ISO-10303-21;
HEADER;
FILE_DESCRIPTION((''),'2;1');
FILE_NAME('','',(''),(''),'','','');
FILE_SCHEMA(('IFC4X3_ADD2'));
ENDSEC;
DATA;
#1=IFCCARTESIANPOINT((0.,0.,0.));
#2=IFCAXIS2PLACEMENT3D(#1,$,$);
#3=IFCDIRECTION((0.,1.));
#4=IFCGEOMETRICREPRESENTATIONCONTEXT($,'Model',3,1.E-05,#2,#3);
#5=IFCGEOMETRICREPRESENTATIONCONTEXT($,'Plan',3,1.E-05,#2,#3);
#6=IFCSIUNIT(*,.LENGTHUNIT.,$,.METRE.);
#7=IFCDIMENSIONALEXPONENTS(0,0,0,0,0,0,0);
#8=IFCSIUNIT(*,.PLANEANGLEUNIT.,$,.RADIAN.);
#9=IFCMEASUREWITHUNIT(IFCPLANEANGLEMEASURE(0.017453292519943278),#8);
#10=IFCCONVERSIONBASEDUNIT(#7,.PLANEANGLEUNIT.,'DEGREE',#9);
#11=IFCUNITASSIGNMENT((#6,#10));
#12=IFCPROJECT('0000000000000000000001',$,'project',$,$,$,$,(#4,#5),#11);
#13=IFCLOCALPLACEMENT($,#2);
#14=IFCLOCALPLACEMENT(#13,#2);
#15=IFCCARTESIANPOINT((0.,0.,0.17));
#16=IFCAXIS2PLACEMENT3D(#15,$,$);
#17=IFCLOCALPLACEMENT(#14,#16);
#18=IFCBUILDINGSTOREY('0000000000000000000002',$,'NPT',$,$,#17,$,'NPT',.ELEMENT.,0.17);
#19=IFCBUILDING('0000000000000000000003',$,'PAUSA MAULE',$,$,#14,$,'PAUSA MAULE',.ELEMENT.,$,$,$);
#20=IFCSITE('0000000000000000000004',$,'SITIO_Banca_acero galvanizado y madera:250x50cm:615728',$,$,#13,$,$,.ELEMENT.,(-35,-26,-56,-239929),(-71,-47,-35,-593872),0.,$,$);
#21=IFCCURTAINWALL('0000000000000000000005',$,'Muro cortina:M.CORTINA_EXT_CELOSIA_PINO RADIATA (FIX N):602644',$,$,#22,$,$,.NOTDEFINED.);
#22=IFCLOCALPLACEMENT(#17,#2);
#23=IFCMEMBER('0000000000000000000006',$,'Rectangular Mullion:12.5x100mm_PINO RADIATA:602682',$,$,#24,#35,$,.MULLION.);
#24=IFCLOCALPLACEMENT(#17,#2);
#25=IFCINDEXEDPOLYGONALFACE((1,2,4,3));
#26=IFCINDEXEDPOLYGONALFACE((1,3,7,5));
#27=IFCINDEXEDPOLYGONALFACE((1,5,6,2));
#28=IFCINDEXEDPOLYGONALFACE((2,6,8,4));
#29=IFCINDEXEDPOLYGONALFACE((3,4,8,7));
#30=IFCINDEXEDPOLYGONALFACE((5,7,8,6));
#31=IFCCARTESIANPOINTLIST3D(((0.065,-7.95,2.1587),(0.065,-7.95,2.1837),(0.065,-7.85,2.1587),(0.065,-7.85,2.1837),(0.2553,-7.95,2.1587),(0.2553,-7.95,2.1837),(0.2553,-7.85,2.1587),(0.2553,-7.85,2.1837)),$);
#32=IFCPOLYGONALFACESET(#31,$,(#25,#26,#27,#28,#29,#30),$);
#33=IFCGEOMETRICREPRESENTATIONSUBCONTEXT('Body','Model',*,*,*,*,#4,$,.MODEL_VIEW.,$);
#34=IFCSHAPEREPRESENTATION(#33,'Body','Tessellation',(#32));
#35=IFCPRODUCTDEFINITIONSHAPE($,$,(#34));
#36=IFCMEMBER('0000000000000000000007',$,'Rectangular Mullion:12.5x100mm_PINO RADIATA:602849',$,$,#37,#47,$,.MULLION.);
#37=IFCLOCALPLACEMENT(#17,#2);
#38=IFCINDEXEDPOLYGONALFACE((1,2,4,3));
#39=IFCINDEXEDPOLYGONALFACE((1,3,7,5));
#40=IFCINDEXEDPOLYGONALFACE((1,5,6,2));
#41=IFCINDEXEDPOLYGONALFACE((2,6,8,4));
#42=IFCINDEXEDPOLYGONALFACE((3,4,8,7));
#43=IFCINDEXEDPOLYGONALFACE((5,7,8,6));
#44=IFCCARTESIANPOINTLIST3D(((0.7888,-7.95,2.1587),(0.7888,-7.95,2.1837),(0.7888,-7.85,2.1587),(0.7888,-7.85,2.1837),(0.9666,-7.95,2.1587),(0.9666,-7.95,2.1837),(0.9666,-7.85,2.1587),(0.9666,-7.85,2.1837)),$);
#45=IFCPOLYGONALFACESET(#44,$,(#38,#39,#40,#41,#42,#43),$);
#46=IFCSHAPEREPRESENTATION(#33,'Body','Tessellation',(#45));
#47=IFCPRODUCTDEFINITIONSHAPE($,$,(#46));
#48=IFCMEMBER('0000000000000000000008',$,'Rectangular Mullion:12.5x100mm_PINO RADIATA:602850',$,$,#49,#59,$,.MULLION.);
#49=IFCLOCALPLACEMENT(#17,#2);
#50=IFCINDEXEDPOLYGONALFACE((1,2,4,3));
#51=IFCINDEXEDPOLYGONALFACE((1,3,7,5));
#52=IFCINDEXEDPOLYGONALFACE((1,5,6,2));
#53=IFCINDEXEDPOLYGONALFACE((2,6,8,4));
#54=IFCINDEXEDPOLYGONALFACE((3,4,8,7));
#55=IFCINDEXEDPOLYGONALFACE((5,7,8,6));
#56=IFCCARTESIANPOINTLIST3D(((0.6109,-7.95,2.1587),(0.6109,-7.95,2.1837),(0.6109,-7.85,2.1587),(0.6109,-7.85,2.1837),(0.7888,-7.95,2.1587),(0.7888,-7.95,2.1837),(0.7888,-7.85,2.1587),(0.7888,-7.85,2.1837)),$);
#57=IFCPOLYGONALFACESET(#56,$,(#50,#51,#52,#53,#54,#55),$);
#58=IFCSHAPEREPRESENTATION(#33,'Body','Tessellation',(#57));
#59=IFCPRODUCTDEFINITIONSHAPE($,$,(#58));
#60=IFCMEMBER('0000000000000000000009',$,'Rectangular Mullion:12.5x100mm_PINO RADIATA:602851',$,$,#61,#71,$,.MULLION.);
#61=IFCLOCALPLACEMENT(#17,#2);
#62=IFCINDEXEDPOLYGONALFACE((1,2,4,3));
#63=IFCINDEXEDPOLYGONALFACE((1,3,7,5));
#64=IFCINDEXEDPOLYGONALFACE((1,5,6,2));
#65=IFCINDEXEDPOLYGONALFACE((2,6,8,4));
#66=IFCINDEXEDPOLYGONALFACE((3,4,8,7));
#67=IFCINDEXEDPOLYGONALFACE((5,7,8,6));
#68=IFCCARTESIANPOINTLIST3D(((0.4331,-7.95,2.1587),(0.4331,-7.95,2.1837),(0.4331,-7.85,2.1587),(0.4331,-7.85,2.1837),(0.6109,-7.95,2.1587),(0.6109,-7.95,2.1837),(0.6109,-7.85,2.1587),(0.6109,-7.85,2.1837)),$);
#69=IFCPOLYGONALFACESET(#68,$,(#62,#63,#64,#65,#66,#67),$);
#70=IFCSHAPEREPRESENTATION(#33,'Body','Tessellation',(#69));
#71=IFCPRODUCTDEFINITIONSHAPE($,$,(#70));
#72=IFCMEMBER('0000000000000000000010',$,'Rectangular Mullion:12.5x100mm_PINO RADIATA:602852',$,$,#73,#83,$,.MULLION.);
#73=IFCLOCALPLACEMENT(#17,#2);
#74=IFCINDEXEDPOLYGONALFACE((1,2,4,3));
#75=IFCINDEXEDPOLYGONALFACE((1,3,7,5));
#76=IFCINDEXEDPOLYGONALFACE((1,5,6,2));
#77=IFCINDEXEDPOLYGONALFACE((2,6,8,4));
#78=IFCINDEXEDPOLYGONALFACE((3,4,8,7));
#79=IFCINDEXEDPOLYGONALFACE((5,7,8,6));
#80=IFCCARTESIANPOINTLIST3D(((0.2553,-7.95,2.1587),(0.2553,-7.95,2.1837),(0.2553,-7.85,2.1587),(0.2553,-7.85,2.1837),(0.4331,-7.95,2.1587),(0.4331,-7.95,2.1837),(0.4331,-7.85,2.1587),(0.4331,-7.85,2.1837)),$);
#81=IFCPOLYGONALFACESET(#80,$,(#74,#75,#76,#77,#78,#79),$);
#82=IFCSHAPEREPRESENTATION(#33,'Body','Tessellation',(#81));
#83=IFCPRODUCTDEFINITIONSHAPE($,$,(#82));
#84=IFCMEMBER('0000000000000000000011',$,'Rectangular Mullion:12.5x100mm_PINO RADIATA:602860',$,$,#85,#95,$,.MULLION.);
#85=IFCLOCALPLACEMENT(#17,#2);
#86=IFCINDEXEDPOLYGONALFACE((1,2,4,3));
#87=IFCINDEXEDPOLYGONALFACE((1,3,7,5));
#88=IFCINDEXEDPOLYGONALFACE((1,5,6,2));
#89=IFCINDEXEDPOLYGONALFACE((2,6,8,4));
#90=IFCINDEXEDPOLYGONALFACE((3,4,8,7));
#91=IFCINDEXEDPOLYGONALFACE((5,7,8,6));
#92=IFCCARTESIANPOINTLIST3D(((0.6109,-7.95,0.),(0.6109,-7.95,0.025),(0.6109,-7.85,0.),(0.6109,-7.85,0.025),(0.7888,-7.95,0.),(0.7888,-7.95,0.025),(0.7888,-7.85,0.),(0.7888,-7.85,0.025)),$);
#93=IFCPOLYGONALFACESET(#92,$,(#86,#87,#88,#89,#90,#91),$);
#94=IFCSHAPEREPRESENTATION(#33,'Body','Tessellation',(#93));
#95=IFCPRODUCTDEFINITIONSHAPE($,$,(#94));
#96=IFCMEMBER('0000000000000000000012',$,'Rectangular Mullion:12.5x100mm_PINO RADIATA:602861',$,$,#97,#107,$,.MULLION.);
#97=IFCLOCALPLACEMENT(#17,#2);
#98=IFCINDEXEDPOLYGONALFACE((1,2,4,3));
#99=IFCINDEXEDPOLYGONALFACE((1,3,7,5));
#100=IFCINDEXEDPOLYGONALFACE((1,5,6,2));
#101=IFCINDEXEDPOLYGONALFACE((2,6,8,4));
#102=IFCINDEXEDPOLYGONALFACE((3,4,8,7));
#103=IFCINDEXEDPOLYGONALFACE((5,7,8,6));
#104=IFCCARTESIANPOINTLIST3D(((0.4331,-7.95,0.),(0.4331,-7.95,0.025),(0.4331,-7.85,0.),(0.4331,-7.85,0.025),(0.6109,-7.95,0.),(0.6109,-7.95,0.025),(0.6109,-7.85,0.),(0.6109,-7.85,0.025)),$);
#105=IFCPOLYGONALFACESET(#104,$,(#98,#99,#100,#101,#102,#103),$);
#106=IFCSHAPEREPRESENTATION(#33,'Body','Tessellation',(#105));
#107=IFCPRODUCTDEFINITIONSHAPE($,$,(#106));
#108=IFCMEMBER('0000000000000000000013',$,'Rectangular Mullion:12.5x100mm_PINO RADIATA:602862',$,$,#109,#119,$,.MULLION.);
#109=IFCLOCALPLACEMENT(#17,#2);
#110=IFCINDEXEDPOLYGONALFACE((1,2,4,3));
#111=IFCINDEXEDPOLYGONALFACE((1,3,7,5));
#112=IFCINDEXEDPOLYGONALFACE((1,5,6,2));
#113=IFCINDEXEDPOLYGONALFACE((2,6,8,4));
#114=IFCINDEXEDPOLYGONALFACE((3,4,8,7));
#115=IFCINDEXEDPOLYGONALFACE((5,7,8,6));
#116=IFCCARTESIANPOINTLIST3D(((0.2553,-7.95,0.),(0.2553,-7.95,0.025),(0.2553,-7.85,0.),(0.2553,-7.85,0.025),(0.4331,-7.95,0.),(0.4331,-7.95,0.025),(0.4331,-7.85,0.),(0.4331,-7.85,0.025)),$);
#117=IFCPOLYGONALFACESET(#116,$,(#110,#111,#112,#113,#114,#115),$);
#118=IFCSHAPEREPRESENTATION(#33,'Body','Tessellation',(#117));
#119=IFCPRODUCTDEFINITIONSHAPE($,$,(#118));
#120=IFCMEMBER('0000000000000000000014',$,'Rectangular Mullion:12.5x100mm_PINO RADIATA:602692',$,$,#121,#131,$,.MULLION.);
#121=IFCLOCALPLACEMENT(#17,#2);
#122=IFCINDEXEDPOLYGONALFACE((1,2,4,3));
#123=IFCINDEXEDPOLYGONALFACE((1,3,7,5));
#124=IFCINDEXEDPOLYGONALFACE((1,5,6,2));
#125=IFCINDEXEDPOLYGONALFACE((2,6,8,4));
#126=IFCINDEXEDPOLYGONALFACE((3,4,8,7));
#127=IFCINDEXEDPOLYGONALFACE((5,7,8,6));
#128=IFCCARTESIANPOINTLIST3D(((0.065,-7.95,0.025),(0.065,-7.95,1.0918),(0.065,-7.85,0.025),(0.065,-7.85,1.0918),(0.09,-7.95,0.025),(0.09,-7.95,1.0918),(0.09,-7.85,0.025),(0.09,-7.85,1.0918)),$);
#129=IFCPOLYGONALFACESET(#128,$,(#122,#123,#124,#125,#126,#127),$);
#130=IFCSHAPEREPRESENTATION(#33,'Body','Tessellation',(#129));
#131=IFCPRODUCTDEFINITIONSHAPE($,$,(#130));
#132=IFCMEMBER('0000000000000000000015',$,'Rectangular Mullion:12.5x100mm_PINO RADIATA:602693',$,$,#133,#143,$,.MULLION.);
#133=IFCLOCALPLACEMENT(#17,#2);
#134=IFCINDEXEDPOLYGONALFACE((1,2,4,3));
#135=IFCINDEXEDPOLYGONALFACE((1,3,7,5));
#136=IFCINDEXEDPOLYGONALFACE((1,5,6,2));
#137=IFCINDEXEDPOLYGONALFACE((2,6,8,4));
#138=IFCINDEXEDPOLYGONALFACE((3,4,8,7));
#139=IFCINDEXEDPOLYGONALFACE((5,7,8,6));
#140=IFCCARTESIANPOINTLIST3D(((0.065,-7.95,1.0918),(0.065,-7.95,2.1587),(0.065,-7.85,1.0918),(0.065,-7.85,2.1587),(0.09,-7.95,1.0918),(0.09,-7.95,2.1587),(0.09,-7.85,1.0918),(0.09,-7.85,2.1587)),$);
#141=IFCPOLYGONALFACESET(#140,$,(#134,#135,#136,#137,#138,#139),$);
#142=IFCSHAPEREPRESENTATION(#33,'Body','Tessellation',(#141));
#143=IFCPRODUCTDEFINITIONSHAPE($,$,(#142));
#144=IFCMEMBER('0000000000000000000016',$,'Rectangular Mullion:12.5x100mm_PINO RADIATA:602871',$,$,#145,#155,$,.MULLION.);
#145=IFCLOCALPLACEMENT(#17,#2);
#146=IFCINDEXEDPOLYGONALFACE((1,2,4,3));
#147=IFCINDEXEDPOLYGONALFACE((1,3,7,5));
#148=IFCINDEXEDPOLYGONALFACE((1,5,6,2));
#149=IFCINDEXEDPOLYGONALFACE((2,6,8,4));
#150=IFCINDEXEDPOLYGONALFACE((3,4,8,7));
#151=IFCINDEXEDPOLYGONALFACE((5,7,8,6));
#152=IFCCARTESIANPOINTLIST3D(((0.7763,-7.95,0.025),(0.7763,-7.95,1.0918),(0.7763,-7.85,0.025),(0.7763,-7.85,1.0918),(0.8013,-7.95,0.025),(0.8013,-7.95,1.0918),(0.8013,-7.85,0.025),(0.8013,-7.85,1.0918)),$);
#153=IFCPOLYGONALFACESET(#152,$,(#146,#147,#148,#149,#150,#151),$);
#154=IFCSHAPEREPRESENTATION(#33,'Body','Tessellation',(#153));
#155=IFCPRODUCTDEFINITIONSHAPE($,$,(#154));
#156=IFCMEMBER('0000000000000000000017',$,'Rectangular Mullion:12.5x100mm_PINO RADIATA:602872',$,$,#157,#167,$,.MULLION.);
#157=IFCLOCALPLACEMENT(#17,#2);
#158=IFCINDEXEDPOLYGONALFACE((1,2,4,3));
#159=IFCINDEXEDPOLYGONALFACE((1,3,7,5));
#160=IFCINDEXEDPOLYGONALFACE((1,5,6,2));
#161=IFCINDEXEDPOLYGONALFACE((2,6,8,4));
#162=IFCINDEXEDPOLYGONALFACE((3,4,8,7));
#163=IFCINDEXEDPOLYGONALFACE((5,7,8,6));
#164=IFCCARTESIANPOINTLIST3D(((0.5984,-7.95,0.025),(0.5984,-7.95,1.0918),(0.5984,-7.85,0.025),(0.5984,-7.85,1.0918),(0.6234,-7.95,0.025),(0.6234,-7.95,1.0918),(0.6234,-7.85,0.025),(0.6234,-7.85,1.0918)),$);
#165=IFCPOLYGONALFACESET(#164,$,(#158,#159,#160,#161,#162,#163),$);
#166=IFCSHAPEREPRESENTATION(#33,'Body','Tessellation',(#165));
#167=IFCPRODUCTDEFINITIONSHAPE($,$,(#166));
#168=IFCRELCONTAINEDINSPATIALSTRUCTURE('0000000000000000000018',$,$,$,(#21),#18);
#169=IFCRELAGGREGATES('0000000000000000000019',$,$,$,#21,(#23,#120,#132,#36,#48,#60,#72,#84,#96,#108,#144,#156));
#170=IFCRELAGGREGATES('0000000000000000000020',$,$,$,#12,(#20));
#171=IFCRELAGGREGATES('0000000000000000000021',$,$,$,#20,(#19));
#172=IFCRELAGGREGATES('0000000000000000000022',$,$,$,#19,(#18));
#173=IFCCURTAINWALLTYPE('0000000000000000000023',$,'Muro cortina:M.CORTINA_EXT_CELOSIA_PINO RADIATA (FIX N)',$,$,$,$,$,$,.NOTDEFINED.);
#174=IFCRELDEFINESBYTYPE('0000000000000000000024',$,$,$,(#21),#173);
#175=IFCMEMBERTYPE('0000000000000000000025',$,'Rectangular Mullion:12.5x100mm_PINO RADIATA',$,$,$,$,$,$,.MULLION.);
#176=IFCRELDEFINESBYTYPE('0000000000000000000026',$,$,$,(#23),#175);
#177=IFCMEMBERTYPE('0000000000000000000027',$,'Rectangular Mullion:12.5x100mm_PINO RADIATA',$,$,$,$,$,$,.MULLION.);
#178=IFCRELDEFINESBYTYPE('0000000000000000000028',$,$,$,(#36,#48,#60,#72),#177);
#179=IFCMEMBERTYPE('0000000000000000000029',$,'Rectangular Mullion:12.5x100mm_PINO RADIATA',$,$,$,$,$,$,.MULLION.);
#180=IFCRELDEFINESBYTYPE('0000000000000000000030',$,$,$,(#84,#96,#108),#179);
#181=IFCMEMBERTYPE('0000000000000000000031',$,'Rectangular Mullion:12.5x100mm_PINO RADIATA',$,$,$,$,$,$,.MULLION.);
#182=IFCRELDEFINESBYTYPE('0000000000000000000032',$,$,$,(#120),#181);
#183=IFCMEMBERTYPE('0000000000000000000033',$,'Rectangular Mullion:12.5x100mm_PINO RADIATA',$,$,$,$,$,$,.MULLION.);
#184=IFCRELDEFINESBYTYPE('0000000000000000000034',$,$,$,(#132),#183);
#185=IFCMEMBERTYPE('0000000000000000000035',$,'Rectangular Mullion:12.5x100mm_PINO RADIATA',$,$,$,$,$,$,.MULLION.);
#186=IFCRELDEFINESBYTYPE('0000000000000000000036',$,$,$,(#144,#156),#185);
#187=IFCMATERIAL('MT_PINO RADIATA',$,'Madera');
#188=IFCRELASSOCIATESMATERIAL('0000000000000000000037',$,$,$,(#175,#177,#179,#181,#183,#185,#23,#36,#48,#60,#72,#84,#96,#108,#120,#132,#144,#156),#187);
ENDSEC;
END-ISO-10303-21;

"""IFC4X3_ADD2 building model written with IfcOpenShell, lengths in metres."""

from ifc_helpers import new_model, entity, si_unit, converted_unit, direction, frame, frame_2d, origin, origin_2d_with_axis, place, context, subcontext, project, spatial, rectangle, extrude, source, transform, mapped, material, material_profile, profile_set, profile_usage, type_object, type_shapes, element, aggregate, save


model = new_model("IFC4X3_ADD2")

# Units and contexts
model_context = context("Model", 3, precision=1e-05, world=origin(), true_north=direction((0.0, 1.0)))
plan_context = context("Plan", 3, precision=1e-05, world=origin(), true_north=direction((0.0, 1.0)))
body_context = subcontext(model_context, "Body", "Model", "MODEL_VIEW")
ifc_project = project(units=[si_unit("LENGTHUNIT", "METRE"), converted_unit("PLANEANGLEUNIT", "DEGREE", entity("IfcPlaneAngleMeasure", 0.017453292519943278), si_unit("PLANEANGLEUNIT", "RADIAN"), dimensions=[0, 0, 0, 0, 0, 0, 0])], contexts=[model_context, plan_context])

# Site, building, storey
site_placement = place(None, origin())
site = spatial("IfcSite", under=ifc_project, at=site_placement, Name="SITIO_Banca_acero galvanizado y madera:250x50cm:615728", CompositionType="ELEMENT", RefLatitude=(-35, -26, -56, -239929), RefLongitude=(-71, -47, -35, -593872), RefElevation=0.0)
building_placement = place(site_placement, origin())
building = spatial("IfcBuilding", under=site, at=building_placement, Name="PAUSA MAULE", LongName="PAUSA MAULE", CompositionType="ELEMENT")
storey_placement = place(building_placement, frame((0.0, 0.0, 0.17)))
storey = spatial("IfcBuildingStorey", under=building, at=storey_placement, Name="NPT", LongName="NPT", CompositionType="ELEMENT", Elevation=0.17)

# Curtain wall, members
curtain_wall_type = type_object("IfcCurtainWallType", Name="Muro cortina:M.CORTINA_EXT_CELOSIA_PINO RADIATA (FIX N)", PredefinedType="NOTDEFINED")
curtain_wall_placement = place(storey_placement, frame((0.0, 0.0, -0.17)))
curtain_wall = element("IfcCurtainWall", 1, at=curtain_wall_placement, inside=storey, type_object=curtain_wall_type, Name="Muro cortina:M.CORTINA_EXT_CELOSIA_PINO RADIATA (FIX N):602644", PredefinedType="NOTDEFINED")
ifc_material_1 = material(Name="MT_PINO RADIATA", Category="Madera")
ifc_material_profile = material_profile(ifc_material_1, rectangle(XDim=0.025, YDim=0.1, at=frame_2d((0.0, 0.0), x_axis=(1.0, 0.0))), Name="12.5x100mm_PINO RADIATA")
ifc_profile_set = profile_set([ifc_material_profile], Name="12.5x100mm_PINO RADIATA")
ifc_profile_usage = profile_usage(ifc_profile_set)
member_type_1 = type_object("IfcMemberType", Name="Rectangular Mullion:12.5x100mm_PINO RADIATA", PredefinedType="MULLION", material=ifc_profile_set)
shared_shape_1 = source(origin(), body_context, "Body", "SweptSolid", [
    extrude(rectangle(XDim=0.025, YDim=0.1, at=frame_2d((0.0, 0.0), x_axis=(1.0, 0.0))), frame((-0.0125, 0.0, -0.1903), z_axis=(0.0, 0.0, 1.0), x_axis=(-1.0, 0.0, 0.0)), (0.0, 0.0, 1.0), 0.1903),
])
type_shapes(member_type_1, [shared_shape_1])
member_1_placement = place(curtain_wall_placement, frame((0.065, -7.9, 2.3537), z_axis=(-1.0, 0.0, 0.0), x_axis=(0.0, 0.0, 1.0)))
member_1 = element("IfcMember", 2, at=member_1_placement, type_object=member_type_1, material=ifc_profile_usage, Name="Rectangular Mullion:12.5x100mm_PINO RADIATA:602682", PredefinedType="MULLION", context=body_context, shape_type="MappedRepresentation", body=[
    mapped(shared_shape_1, transform((0.0, 0.0, 0.0), scale=1.0)),
])
member_type_2 = type_object("IfcMemberType", Name="Rectangular Mullion:12.5x100mm_PINO RADIATA", PredefinedType="MULLION", material=ifc_profile_set)
shared_shape_2 = source(origin(), body_context, "Body", "SweptSolid", [
    extrude(rectangle(XDim=0.025, YDim=0.1, at=frame_2d((0.0, 0.0), x_axis=(1.0, 0.0))), frame((-0.0125, 0.0, -0.1778), z_axis=(0.0, 0.0, 1.0), x_axis=(-1.0, 0.0, 0.0)), (0.0, 0.0, 1.0), 0.1778),
])
type_shapes(member_type_2, [shared_shape_2])
member_2_placement = place(curtain_wall_placement, frame((0.7888, -7.9, 2.3537), z_axis=(-1.0, 0.0, 0.0), x_axis=(0.0, 0.0, 1.0)))
member_2 = element("IfcMember", 3, at=member_2_placement, type_object=member_type_2, material=ifc_profile_usage, Name="Rectangular Mullion:12.5x100mm_PINO RADIATA:602849", PredefinedType="MULLION", context=body_context, shape_type="MappedRepresentation", body=[
    mapped(shared_shape_2, transform((0.0, 0.0, 0.0), scale=1.0)),
])
member_3_placement = place(curtain_wall_placement, frame((0.6109, -7.9, 2.3537), z_axis=(-1.0, 0.0, 0.0), x_axis=(0.0, 0.0, 1.0)))
member_3 = element("IfcMember", 4, at=member_3_placement, type_object=member_type_2, material=ifc_profile_usage, Name="Rectangular Mullion:12.5x100mm_PINO RADIATA:602850", PredefinedType="MULLION", context=body_context, shape_type="MappedRepresentation", body=[
    mapped(shared_shape_2, transform((0.0, 0.0, 0.0), scale=1.0)),
])
member_4_placement = place(curtain_wall_placement, frame((0.4331, -7.9, 2.3537), z_axis=(-1.0, 0.0, 0.0), x_axis=(0.0, 0.0, 1.0)))
member_4 = element("IfcMember", 5, at=member_4_placement, type_object=member_type_2, material=ifc_profile_usage, Name="Rectangular Mullion:12.5x100mm_PINO RADIATA:602851", PredefinedType="MULLION", context=body_context, shape_type="MappedRepresentation", body=[
    mapped(shared_shape_2, transform((0.0, 0.0, 0.0), scale=1.0)),
])
member_5_placement = place(curtain_wall_placement, frame((0.2553, -7.9, 2.3537), z_axis=(-1.0, 0.0, 0.0), x_axis=(0.0, 0.0, 1.0)))
member_5 = element("IfcMember", 6, at=member_5_placement, type_object=member_type_2, material=ifc_profile_usage, Name="Rectangular Mullion:12.5x100mm_PINO RADIATA:602852", PredefinedType="MULLION", context=body_context, shape_type="MappedRepresentation", body=[
    mapped(shared_shape_2, transform((0.0, 0.0, 0.0), scale=1.0)),
])
member_type_3 = type_object("IfcMemberType", Name="Rectangular Mullion:12.5x100mm_PINO RADIATA", PredefinedType="MULLION", material=ifc_profile_set)
shared_shape_3 = source(origin(), body_context, "Body", "SweptSolid", [
    extrude(rectangle(XDim=0.025, YDim=0.1, at=frame_2d((0.0, 0.0), x_axis=(1.0, 0.0))), frame((-0.0125, 0.0, -0.1778), z_axis=(0.0, 0.0, 1.0), x_axis=(-1.0, 0.0, 0.0)), (0.0, 0.0, 1.0), 0.1778),
])
type_shapes(member_type_3, [shared_shape_3])
member_6_placement = place(curtain_wall_placement, frame((0.7888, -7.9, 0.17), z_axis=(1.0, 0.0, 0.0), x_axis=(0.0, 0.0, -1.0)))
member_6 = element("IfcMember", 7, at=member_6_placement, type_object=member_type_3, material=ifc_profile_usage, Name="Rectangular Mullion:12.5x100mm_PINO RADIATA:602860", PredefinedType="MULLION", context=body_context, shape_type="MappedRepresentation", body=[
    mapped(shared_shape_3, transform((0.0, 0.0, 0.0), scale=1.0)),
])
member_7_placement = place(curtain_wall_placement, frame((0.6109, -7.9, 0.17), z_axis=(1.0, 0.0, 0.0), x_axis=(0.0, 0.0, -1.0)))
member_7 = element("IfcMember", 8, at=member_7_placement, type_object=member_type_3, material=ifc_profile_usage, Name="Rectangular Mullion:12.5x100mm_PINO RADIATA:602861", PredefinedType="MULLION", context=body_context, shape_type="MappedRepresentation", body=[
    mapped(shared_shape_3, transform((0.0, 0.0, 0.0), scale=1.0)),
])
member_8_placement = place(curtain_wall_placement, frame((0.4331, -7.9, 0.17), z_axis=(1.0, 0.0, 0.0), x_axis=(0.0, 0.0, -1.0)))
member_8 = element("IfcMember", 9, at=member_8_placement, type_object=member_type_3, material=ifc_profile_usage, Name="Rectangular Mullion:12.5x100mm_PINO RADIATA:602862", PredefinedType="MULLION", context=body_context, shape_type="MappedRepresentation", body=[
    mapped(shared_shape_3, transform((0.0, 0.0, 0.0), scale=1.0)),
])
member_type_4 = type_object("IfcMemberType", Name="Rectangular Mullion:12.5x100mm_PINO RADIATA", PredefinedType="MULLION", material=ifc_profile_set)
shared_shape_4 = source(origin(), body_context, "Body", "SweptSolid", [
    extrude(rectangle(XDim=0.025, YDim=0.1, at=origin_2d_with_axis()), frame((-0.0125, 0.0, -1.0668), z_axis=(0.0, 0.0, 1.0), x_axis=(-1.0, 0.0, 0.0)), (0.0, 0.0, 1.0), 1.0668),
])
type_shapes(member_type_4, [shared_shape_4])
member_9_placement = place(curtain_wall_placement, frame((0.065, -7.9, 0.195), z_axis=(0.0, 0.0, -1.0), x_axis=(-1.0, 0.0, 0.0)))
member_9 = element("IfcMember", 10, at=member_9_placement, type_object=member_type_4, material=ifc_profile_usage, Name="Rectangular Mullion:12.5x100mm_PINO RADIATA:602692", PredefinedType="MULLION", context=body_context, shape_type="MappedRepresentation", body=[
    mapped(shared_shape_4, transform((0.0, 0.0, 0.0), scale=1.0)),
])
member_type_5 = type_object("IfcMemberType", Name="Rectangular Mullion:12.5x100mm_PINO RADIATA", PredefinedType="MULLION", material=ifc_profile_set)
shared_shape_5 = source(origin(), body_context, "Body", "SweptSolid", [
    extrude(rectangle(XDim=0.025, YDim=0.1, at=frame_2d((0.0, 0.0), x_axis=(1.0, 0.0))), frame((-0.0125, 0.0, -1.0668), z_axis=(0.0, 0.0, 1.0), x_axis=(-1.0, 0.0, 0.0)), (0.0, 0.0, 1.0), 1.0668),
])
type_shapes(member_type_5, [shared_shape_5])
member_10_placement = place(curtain_wall_placement, frame((0.065, -7.9, 1.2618), z_axis=(0.0, 0.0, -1.0), x_axis=(-1.0, 0.0, 0.0)))
member_10 = element("IfcMember", 11, at=member_10_placement, type_object=member_type_5, material=ifc_profile_usage, Name="Rectangular Mullion:12.5x100mm_PINO RADIATA:602693", PredefinedType="MULLION", context=body_context, shape_type="MappedRepresentation", body=[
    mapped(shared_shape_5, transform((0.0, 0.0, 0.0), scale=1.0)),
])
member_type_6 = type_object("IfcMemberType", Name="Rectangular Mullion:12.5x100mm_PINO RADIATA", PredefinedType="MULLION", material=ifc_profile_set)
shared_shape_6 = source(origin(), body_context, "Body", "SweptSolid", [
    extrude(rectangle(XDim=0.025, YDim=0.1, at=origin_2d_with_axis()), frame((0.0, 0.0, -1.0668), z_axis=(0.0, 0.0, 1.0), x_axis=(-1.0, 0.0, 0.0)), (0.0, 0.0, 1.0), 1.0668),
])
type_shapes(member_type_6, [shared_shape_6])
member_11_placement = place(curtain_wall_placement, frame((0.7888, -7.9, 0.195), z_axis=(0.0, 0.0, -1.0), x_axis=(-1.0, 0.0, 0.0)))
member_11 = element("IfcMember", 12, at=member_11_placement, type_object=member_type_6, material=ifc_profile_usage, Name="Rectangular Mullion:12.5x100mm_PINO RADIATA:602871", PredefinedType="MULLION", context=body_context, shape_type="MappedRepresentation", body=[
    mapped(shared_shape_6, transform((0.0, 0.0, 0.0), scale=1.0)),
])
member_12_placement = place(curtain_wall_placement, frame((0.6109, -7.9, 0.195), z_axis=(0.0, 0.0, -1.0), x_axis=(-1.0, 0.0, 0.0)))
member_12 = element("IfcMember", 13, at=member_12_placement, type_object=member_type_6, material=ifc_profile_usage, Name="Rectangular Mullion:12.5x100mm_PINO RADIATA:602872", PredefinedType="MULLION", context=body_context, shape_type="MappedRepresentation", body=[
    mapped(shared_shape_6, transform((0.0, 0.0, 0.0), scale=1.0)),
])
aggregate(curtain_wall, [member_1, member_9, member_10, member_2, member_3, member_4, member_5, member_6, member_7, member_8, member_11, member_12])

save(model, "model.ifc")
